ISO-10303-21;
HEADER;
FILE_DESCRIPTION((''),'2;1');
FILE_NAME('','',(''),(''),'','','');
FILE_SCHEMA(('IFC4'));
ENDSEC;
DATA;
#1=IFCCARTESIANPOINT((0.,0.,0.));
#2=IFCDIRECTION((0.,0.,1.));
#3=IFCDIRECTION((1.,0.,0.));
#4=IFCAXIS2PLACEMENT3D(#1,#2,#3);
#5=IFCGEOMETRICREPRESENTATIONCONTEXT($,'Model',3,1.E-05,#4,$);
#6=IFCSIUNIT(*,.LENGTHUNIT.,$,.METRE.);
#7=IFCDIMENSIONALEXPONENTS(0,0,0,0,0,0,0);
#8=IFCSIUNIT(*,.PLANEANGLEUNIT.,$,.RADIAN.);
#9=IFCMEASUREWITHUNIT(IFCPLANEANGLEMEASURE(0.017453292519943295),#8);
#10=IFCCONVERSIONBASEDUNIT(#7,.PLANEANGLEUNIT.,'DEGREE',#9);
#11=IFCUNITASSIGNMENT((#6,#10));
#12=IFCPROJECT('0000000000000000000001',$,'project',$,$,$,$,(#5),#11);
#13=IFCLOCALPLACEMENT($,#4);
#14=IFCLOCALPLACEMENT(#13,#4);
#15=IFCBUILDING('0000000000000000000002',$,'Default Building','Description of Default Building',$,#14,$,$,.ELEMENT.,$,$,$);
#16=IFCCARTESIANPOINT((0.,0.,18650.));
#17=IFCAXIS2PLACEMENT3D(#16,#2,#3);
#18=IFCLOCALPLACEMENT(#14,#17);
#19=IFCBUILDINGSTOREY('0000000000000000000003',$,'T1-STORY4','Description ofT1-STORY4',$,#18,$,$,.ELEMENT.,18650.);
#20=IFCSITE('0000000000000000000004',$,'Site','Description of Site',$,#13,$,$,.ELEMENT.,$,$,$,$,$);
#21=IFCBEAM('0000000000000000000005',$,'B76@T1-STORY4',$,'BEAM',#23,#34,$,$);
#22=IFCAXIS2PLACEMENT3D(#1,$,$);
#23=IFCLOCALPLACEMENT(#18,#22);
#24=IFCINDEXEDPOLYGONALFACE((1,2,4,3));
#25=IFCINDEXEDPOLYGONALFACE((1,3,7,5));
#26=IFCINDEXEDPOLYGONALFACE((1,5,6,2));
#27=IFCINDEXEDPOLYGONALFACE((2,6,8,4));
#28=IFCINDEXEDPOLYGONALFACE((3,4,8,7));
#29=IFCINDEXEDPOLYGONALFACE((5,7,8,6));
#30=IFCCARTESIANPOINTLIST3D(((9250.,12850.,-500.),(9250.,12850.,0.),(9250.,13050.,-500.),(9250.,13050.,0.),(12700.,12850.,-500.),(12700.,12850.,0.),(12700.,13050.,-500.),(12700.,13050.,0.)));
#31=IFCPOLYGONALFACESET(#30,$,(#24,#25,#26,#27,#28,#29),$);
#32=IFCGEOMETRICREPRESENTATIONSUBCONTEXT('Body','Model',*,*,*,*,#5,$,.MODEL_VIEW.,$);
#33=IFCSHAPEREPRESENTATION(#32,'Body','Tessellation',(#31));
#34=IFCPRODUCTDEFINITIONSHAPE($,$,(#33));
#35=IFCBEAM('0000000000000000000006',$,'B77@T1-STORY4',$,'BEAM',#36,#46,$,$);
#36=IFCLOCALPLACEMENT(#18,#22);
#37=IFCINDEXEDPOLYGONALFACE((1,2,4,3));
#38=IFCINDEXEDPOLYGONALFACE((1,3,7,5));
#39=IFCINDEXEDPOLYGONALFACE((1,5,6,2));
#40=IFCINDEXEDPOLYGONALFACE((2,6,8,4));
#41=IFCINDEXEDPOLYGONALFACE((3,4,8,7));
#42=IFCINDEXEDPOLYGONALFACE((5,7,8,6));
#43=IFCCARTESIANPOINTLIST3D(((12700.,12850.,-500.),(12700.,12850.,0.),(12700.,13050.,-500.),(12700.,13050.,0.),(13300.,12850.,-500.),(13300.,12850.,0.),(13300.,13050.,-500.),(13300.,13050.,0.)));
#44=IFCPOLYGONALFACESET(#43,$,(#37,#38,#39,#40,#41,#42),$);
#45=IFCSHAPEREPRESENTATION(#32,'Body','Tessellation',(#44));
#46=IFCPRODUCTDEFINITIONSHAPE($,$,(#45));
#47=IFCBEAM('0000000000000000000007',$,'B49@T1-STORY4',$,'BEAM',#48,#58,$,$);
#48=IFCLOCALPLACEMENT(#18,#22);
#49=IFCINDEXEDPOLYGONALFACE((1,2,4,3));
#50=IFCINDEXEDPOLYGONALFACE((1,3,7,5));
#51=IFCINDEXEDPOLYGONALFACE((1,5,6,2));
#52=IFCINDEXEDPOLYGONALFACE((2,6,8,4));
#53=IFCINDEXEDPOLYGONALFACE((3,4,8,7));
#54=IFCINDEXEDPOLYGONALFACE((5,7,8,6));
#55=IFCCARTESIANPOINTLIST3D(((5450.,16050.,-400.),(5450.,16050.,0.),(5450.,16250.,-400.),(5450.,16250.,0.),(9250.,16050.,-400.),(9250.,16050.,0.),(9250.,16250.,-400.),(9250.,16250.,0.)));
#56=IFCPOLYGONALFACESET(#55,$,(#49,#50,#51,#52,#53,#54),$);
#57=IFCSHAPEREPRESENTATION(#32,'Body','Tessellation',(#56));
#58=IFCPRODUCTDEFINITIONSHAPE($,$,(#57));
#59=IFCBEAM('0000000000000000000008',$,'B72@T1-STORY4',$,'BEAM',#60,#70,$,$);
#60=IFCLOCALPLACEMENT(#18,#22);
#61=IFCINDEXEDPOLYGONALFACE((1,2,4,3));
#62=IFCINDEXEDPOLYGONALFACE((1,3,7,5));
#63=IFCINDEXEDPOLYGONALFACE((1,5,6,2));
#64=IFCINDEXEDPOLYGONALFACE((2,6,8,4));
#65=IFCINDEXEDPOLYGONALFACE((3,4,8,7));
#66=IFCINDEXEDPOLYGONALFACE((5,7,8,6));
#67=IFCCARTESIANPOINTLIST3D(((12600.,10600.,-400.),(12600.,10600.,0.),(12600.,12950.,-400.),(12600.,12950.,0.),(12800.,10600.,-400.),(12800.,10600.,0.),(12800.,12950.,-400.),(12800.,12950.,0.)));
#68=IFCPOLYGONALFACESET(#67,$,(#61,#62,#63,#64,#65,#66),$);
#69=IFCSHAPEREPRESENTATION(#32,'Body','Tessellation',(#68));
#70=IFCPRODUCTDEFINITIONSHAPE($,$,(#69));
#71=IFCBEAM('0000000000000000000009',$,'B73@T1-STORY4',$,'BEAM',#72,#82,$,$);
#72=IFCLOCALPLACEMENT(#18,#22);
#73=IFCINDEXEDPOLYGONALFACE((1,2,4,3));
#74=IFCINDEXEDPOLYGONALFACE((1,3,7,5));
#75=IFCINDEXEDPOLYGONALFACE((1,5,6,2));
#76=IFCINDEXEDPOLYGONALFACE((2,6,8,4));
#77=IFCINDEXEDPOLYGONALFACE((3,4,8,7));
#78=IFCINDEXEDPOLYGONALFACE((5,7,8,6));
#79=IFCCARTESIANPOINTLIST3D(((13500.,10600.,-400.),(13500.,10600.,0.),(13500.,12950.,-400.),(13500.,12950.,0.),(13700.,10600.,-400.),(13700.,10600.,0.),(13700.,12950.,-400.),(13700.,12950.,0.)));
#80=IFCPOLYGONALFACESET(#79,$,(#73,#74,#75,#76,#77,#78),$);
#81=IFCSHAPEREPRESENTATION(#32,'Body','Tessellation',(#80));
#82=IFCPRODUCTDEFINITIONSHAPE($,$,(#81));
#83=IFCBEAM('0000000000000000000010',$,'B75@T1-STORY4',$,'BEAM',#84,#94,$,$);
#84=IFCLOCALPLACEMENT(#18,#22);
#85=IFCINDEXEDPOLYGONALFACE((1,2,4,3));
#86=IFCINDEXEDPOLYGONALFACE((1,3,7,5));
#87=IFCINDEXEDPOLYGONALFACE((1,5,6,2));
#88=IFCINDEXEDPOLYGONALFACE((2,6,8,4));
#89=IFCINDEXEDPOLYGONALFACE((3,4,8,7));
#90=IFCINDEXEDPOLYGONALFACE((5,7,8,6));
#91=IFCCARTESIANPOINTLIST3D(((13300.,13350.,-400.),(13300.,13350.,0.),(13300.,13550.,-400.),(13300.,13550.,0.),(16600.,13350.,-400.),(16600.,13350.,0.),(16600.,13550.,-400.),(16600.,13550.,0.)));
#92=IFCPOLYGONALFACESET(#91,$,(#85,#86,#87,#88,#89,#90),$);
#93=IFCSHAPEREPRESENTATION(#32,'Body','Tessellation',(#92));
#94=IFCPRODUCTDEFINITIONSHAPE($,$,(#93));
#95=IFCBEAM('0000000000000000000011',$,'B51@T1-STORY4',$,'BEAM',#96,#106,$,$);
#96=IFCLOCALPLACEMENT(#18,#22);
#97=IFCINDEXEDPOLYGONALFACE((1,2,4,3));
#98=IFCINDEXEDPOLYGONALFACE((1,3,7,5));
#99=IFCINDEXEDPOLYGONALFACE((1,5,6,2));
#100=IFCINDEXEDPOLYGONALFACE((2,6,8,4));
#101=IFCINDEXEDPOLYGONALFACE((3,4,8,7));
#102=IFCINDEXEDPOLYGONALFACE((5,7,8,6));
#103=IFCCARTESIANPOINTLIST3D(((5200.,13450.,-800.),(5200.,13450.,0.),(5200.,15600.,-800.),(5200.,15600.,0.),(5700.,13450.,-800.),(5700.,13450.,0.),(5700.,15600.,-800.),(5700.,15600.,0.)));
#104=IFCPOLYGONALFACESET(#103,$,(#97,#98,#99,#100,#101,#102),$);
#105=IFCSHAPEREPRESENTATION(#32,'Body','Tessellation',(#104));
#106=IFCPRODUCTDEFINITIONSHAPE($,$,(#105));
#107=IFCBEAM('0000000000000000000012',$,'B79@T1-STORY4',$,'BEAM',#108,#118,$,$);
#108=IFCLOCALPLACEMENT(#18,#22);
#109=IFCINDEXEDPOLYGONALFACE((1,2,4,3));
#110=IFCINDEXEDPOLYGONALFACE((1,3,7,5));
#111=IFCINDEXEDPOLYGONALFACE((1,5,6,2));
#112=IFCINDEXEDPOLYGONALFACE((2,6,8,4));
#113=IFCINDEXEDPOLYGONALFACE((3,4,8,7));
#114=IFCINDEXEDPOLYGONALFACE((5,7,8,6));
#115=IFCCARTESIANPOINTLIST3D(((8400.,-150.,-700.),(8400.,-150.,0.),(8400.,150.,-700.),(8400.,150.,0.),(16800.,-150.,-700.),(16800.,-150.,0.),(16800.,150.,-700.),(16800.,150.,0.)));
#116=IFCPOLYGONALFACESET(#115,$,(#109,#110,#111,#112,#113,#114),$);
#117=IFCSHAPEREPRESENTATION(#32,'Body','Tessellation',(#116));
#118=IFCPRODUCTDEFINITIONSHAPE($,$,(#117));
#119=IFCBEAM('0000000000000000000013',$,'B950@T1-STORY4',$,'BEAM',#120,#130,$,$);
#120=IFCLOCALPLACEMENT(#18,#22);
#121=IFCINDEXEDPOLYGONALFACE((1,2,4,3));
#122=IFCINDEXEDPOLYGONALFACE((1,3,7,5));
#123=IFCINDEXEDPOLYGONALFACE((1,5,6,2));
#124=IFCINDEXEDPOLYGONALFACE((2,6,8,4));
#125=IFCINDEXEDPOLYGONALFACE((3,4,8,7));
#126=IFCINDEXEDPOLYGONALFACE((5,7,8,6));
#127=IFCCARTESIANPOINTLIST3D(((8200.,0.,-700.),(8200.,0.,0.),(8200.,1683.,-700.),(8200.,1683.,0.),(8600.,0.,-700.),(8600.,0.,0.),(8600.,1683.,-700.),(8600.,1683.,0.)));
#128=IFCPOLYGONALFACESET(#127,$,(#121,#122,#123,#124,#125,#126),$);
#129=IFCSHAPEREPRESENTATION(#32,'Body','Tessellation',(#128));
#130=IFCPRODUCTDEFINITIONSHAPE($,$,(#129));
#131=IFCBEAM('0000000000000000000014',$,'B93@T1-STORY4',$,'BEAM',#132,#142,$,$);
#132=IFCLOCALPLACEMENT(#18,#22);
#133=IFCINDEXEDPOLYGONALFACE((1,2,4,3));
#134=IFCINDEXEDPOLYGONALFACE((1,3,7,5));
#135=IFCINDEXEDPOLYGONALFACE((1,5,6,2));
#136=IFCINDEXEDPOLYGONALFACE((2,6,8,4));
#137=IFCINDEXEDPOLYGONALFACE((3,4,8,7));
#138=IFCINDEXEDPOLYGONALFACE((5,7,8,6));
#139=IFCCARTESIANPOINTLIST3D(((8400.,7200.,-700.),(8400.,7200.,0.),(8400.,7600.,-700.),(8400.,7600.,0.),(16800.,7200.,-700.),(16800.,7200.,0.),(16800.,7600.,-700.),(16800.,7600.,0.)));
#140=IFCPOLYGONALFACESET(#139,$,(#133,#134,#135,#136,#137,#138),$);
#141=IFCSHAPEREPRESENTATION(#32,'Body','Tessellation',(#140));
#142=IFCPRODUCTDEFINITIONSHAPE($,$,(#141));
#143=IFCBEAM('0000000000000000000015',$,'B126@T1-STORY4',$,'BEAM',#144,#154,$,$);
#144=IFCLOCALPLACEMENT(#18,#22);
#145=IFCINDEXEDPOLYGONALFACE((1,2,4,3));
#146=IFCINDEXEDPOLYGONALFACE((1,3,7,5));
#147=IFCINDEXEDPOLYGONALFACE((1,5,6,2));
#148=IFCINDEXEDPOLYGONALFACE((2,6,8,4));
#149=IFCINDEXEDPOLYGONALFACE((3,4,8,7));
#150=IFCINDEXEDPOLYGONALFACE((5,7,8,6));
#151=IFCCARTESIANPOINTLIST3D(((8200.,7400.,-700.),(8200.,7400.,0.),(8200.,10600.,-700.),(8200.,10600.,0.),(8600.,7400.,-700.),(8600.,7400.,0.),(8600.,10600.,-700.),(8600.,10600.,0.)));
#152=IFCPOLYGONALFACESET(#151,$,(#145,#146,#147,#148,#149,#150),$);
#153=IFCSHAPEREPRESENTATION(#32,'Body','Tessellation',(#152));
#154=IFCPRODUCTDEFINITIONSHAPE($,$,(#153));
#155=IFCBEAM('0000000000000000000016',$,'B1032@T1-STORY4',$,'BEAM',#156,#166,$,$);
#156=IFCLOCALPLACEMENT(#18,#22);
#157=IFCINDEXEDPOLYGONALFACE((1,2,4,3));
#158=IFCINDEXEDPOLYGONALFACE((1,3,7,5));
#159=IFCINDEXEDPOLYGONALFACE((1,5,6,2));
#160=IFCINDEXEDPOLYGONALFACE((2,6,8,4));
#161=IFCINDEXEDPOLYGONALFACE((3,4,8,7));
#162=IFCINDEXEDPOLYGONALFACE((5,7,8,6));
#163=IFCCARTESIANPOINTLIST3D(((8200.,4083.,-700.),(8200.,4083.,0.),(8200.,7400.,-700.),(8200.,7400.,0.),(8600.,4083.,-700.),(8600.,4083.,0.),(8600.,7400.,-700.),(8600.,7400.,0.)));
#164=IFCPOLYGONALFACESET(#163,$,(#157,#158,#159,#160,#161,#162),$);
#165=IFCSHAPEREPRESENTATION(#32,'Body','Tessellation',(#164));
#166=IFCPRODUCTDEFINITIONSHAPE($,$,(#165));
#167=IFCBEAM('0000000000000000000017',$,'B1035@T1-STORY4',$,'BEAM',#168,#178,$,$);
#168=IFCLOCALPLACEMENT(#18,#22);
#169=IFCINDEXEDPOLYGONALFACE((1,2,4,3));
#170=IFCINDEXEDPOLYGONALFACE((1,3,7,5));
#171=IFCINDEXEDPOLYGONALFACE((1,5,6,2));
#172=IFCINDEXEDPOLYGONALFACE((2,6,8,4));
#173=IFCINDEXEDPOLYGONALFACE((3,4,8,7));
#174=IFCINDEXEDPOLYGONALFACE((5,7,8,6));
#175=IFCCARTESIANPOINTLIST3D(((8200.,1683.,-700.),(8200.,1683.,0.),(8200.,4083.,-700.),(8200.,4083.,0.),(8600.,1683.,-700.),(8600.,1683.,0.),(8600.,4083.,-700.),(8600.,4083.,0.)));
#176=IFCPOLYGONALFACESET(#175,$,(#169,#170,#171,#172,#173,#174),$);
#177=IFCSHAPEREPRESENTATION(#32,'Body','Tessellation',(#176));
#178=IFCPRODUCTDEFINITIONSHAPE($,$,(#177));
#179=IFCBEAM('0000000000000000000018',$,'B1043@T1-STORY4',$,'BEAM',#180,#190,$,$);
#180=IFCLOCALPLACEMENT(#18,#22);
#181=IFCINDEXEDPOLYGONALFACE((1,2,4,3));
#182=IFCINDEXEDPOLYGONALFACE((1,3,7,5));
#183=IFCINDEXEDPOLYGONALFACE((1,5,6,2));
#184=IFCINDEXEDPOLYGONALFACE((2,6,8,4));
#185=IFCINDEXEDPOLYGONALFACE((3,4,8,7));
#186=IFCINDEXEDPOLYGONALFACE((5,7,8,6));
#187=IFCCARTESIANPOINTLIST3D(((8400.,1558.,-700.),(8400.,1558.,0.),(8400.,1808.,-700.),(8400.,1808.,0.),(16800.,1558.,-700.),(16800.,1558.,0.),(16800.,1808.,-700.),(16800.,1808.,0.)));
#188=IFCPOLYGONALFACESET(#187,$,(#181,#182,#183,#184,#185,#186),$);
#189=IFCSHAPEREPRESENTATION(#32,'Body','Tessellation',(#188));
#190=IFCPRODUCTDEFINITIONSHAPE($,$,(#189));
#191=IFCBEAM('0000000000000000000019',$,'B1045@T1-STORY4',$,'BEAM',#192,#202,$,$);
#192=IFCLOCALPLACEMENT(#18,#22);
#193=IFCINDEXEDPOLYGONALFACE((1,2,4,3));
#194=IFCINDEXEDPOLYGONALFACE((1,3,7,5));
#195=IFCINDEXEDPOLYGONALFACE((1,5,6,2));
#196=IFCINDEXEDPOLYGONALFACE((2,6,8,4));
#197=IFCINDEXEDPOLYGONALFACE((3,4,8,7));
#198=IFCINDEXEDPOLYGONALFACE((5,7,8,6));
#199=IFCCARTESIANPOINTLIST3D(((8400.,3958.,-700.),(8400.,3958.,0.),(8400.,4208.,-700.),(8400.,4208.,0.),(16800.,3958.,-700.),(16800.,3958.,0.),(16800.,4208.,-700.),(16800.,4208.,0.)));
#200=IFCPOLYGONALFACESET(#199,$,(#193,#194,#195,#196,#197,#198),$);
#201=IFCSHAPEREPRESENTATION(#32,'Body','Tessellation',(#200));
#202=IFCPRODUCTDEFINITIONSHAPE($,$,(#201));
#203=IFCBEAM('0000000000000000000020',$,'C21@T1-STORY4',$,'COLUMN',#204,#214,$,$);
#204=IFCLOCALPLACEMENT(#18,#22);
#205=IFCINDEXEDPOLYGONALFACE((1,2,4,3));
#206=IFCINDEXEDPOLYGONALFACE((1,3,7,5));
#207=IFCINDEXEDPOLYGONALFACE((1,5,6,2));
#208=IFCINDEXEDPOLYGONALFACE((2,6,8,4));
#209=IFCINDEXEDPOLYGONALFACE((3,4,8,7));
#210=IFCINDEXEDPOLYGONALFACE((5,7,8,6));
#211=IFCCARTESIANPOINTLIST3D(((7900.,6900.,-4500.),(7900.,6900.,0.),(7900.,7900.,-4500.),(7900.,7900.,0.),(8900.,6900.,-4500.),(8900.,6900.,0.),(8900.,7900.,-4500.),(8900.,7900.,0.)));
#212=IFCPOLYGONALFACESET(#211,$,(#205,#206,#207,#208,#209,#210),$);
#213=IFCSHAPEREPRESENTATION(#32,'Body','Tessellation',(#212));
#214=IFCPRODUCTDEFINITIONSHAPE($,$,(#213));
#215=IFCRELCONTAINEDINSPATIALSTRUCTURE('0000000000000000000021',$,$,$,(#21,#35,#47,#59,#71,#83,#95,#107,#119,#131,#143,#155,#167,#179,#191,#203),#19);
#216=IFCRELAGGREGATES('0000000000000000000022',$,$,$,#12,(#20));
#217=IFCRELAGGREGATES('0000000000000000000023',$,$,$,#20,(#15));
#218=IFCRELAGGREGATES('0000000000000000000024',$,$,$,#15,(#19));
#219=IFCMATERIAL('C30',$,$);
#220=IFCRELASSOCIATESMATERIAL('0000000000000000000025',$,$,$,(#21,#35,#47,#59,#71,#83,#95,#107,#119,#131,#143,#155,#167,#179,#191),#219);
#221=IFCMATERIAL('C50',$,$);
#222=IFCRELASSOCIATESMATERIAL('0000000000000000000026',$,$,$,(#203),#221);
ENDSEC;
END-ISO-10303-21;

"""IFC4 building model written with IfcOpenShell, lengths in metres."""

from ifc_helpers import new_model, entity, si_unit, converted_unit, frame, origin_with_axes, place, context, subcontext, project, spatial, rectangle, extrude, material, element, save


model = new_model("IFC4")

# Units and contexts
model_context = context("Model", 3, precision=1e-05, world=origin_with_axes())
body_context = subcontext(model_context, "Body", "Model", "MODEL_VIEW")
ifc_project = project(units=[si_unit("LENGTHUNIT", "METRE"), converted_unit("PLANEANGLEUNIT", "DEGREE", entity("IfcPlaneAngleMeasure", 0.017453292519943295), si_unit("PLANEANGLEUNIT", "RADIAN"), dimensions=[0, 0, 0, 0, 0, 0, 0])], contexts=[model_context])

# Site, building, storey
site_placement = place(None, origin_with_axes())
site = spatial("IfcSite", under=ifc_project, at=site_placement, Name="Site", Description="Description of Site", CompositionType="ELEMENT")
building_placement = place(site_placement, origin_with_axes())
building = spatial("IfcBuilding", under=site, at=building_placement, Name="Default Building", Description="Description of Default Building", CompositionType="ELEMENT")
storey_placement = place(building_placement, frame((0.0, 0.0, 18650.0), z_axis=(0.0, 0.0, 1.0), x_axis=(1.0, 0.0, 0.0)))
storey = spatial("IfcBuildingStorey", under=building, at=storey_placement, Name="T1-STORY4", Description="Description ofT1-STORY4", CompositionType="ELEMENT", Elevation=18650.0)

# Beams
ifc_material_1 = material(Name="C30")
beam_1_placement = place(storey_placement, frame((9250.0, 12950.0, -250.0), z_axis=(1.0, 0.0, 0.0), x_axis=(0.0, 1.0, 0.0)))
element("IfcBeam", 1, at=beam_1_placement, inside=storey, material=ifc_material_1, Name="B76@T1-STORY4", ObjectType="BEAM", context=body_context, shape_type="SweptSolid", body=[
    extrude(rectangle(XDim=200.0, YDim=500.0), origin_with_axes(), (0.0, 0.0, 1.0), 3450.0),
])
beam_2_placement = place(storey_placement, frame((12700.0, 12950.0, -250.0), z_axis=(1.0, 0.0, 0.0), x_axis=(0.0, 1.0, 0.0)))
element("IfcBeam", 2, at=beam_2_placement, inside=storey, material=ifc_material_1, Name="B77@T1-STORY4", ObjectType="BEAM", context=body_context, shape_type="SweptSolid", body=[
    extrude(rectangle(XDim=200.0, YDim=500.0), origin_with_axes(), (0.0, 0.0, 1.0), 600.0),
])
beam_3_placement = place(storey_placement, frame((5450.0, 16150.0, -200.0), z_axis=(1.0, 0.0, 0.0), x_axis=(0.0, 1.0, 0.0)))
element("IfcBeam", 3, at=beam_3_placement, inside=storey, material=ifc_material_1, Name="B49@T1-STORY4", ObjectType="BEAM", context=body_context, shape_type="SweptSolid", body=[
    extrude(rectangle(XDim=200.0, YDim=400.0), origin_with_axes(), (0.0, 0.0, 1.0), 3800.0),
])
for number, where, z_axis, x_axis, name in (
    (4, (12700.0, 10600.0, -200.0), (0.0, 1.0, 0.0), (-1.0, 0.0, 0.0), "B72@T1-STORY4"),
    (5, (13600.0, 10600.0, -200.0), (0.0, 1.0, 0.0), (-1.0, 0.0, 0.0), "B73@T1-STORY4"),
):
    element("IfcBeam", number, at=place(storey_placement, frame(where, z_axis=z_axis, x_axis=x_axis)), inside=storey, material=ifc_material_1, Name=name, ObjectType="BEAM", context=body_context, shape_type="SweptSolid", body=[
        extrude(rectangle(XDim=200.0, YDim=400.0), origin_with_axes(), (0.0, 0.0, 1.0), 2350.0),
    ])
beam_4_placement = place(storey_placement, frame((13300.0, 13450.0, -200.0), z_axis=(1.0, 0.0, 0.0), x_axis=(0.0, 1.0, 0.0)))
element("IfcBeam", 6, at=beam_4_placement, inside=storey, material=ifc_material_1, Name="B75@T1-STORY4", ObjectType="BEAM", context=body_context, shape_type="SweptSolid", body=[
    extrude(rectangle(XDim=200.0, YDim=400.0), origin_with_axes(), (0.0, 0.0, 1.0), 3300.0),
])
beam_5_placement = place(storey_placement, frame((5450.0, 13450.0, -400.0), z_axis=(0.0, 1.0, 0.0), x_axis=(-1.0, 0.0, 0.0)))
element("IfcBeam", 7, at=beam_5_placement, inside=storey, material=ifc_material_1, Name="B51@T1-STORY4", ObjectType="BEAM", context=body_context, shape_type="SweptSolid", body=[
    extrude(rectangle(XDim=500.0, YDim=800.0), origin_with_axes(), (0.0, 0.0, 1.0), 2150.0),
])
beam_6_placement = place(storey_placement, frame((8400.0, 0.0, -350.0), z_axis=(1.0, 0.0, 0.0), x_axis=(0.0, 1.0, 0.0)))
element("IfcBeam", 8, at=beam_6_placement, inside=storey, material=ifc_material_1, Name="B79@T1-STORY4", ObjectType="BEAM", context=body_context, shape_type="SweptSolid", body=[
    extrude(rectangle(XDim=300.0, YDim=700.0), origin_with_axes(), (0.0, 0.0, 1.0), 8400.0),
])
beam_7_placement = place(storey_placement, frame((8400.0, 0.0, -350.0), z_axis=(0.0, 1.0, 0.0), x_axis=(-1.0, 0.0, 0.0)))
element("IfcBeam", 9, at=beam_7_placement, inside=storey, material=ifc_material_1, Name="B950@T1-STORY4", ObjectType="BEAM", context=body_context, shape_type="SweptSolid", body=[
    extrude(rectangle(XDim=400.0, YDim=700.0), origin_with_axes(), (0.0, 0.0, 1.0), 1683.0),
])
beam_8_placement = place(storey_placement, frame((8400.0, 7400.0, -350.0), z_axis=(1.0, 0.0, 0.0), x_axis=(0.0, 1.0, 0.0)))
element("IfcBeam", 10, at=beam_8_placement, inside=storey, material=ifc_material_1, Name="B93@T1-STORY4", ObjectType="BEAM", context=body_context, shape_type="SweptSolid", body=[
    extrude(rectangle(XDim=400.0, YDim=700.0), origin_with_axes(), (0.0, 0.0, 1.0), 8400.0),
])
beam_9_placement = place(storey_placement, frame((8400.0, 7400.0, -350.0), z_axis=(0.0, 1.0, 0.0), x_axis=(-1.0, 0.0, 0.0)))
element("IfcBeam", 11, at=beam_9_placement, inside=storey, material=ifc_material_1, Name="B126@T1-STORY4", ObjectType="BEAM", context=body_context, shape_type="SweptSolid", body=[
    extrude(rectangle(XDim=400.0, YDim=700.0), origin_with_axes(), (0.0, 0.0, 1.0), 3200.0),
])
beam_10_placement = place(storey_placement, frame((8400.0, 4083.0, -350.0), z_axis=(0.0, 1.0, 0.0), x_axis=(-1.0, 0.0, 0.0)))
element("IfcBeam", 12, at=beam_10_placement, inside=storey, material=ifc_material_1, Name="B1032@T1-STORY4", ObjectType="BEAM", context=body_context, shape_type="SweptSolid", body=[
    extrude(rectangle(XDim=400.0, YDim=700.0), origin_with_axes(), (0.0, 0.0, 1.0), 3317.0),
])
beam_11_placement = place(storey_placement, frame((8400.0, 1683.0, -350.0), z_axis=(0.0, 1.0, 0.0), x_axis=(-1.0, 0.0, 0.0)))
element("IfcBeam", 13, at=beam_11_placement, inside=storey, material=ifc_material_1, Name="B1035@T1-STORY4", ObjectType="BEAM", context=body_context, shape_type="SweptSolid", body=[
    extrude(rectangle(XDim=400.0, YDim=700.0), origin_with_axes(), (0.0, 0.0, 1.0), 2400.0),
])
for number, where, z_axis, x_axis, name in (
    (14, (8400.0, 1683.0, -350.0), (1.0, 0.0, 0.0), (0.0, 1.0, 0.0), "B1043@T1-STORY4"),
    (15, (8400.0, 4083.0, -350.0), (1.0, 0.0, 0.0), (0.0, 1.0, 0.0), "B1045@T1-STORY4"),
):
    element("IfcBeam", number, at=place(storey_placement, frame(where, z_axis=z_axis, x_axis=x_axis)), inside=storey, material=ifc_material_1, Name=name, ObjectType="BEAM", context=body_context, shape_type="SweptSolid", body=[
        extrude(rectangle(XDim=250.0, YDim=700.0), origin_with_axes(), (0.0, 0.0, 1.0), 8400.0),
    ])
ifc_material_2 = material(Name="C50")
beam_12_placement = place(storey_placement, frame((8400.0, 7400.0, -4500.0), z_axis=(0.0, 0.0, 1.0), x_axis=(0.0, -1.0, 0.0)))
element("IfcBeam", 16, at=beam_12_placement, inside=storey, material=ifc_material_2, Name="C21@T1-STORY4", ObjectType="COLUMN", context=body_context, shape_type="SweptSolid", body=[
    extrude(rectangle(XDim=1000.0, YDim=1000.0), origin_with_axes(), (0.0, 0.0, 1.0), 4500.0),
])

save(model, "model.ifc")
